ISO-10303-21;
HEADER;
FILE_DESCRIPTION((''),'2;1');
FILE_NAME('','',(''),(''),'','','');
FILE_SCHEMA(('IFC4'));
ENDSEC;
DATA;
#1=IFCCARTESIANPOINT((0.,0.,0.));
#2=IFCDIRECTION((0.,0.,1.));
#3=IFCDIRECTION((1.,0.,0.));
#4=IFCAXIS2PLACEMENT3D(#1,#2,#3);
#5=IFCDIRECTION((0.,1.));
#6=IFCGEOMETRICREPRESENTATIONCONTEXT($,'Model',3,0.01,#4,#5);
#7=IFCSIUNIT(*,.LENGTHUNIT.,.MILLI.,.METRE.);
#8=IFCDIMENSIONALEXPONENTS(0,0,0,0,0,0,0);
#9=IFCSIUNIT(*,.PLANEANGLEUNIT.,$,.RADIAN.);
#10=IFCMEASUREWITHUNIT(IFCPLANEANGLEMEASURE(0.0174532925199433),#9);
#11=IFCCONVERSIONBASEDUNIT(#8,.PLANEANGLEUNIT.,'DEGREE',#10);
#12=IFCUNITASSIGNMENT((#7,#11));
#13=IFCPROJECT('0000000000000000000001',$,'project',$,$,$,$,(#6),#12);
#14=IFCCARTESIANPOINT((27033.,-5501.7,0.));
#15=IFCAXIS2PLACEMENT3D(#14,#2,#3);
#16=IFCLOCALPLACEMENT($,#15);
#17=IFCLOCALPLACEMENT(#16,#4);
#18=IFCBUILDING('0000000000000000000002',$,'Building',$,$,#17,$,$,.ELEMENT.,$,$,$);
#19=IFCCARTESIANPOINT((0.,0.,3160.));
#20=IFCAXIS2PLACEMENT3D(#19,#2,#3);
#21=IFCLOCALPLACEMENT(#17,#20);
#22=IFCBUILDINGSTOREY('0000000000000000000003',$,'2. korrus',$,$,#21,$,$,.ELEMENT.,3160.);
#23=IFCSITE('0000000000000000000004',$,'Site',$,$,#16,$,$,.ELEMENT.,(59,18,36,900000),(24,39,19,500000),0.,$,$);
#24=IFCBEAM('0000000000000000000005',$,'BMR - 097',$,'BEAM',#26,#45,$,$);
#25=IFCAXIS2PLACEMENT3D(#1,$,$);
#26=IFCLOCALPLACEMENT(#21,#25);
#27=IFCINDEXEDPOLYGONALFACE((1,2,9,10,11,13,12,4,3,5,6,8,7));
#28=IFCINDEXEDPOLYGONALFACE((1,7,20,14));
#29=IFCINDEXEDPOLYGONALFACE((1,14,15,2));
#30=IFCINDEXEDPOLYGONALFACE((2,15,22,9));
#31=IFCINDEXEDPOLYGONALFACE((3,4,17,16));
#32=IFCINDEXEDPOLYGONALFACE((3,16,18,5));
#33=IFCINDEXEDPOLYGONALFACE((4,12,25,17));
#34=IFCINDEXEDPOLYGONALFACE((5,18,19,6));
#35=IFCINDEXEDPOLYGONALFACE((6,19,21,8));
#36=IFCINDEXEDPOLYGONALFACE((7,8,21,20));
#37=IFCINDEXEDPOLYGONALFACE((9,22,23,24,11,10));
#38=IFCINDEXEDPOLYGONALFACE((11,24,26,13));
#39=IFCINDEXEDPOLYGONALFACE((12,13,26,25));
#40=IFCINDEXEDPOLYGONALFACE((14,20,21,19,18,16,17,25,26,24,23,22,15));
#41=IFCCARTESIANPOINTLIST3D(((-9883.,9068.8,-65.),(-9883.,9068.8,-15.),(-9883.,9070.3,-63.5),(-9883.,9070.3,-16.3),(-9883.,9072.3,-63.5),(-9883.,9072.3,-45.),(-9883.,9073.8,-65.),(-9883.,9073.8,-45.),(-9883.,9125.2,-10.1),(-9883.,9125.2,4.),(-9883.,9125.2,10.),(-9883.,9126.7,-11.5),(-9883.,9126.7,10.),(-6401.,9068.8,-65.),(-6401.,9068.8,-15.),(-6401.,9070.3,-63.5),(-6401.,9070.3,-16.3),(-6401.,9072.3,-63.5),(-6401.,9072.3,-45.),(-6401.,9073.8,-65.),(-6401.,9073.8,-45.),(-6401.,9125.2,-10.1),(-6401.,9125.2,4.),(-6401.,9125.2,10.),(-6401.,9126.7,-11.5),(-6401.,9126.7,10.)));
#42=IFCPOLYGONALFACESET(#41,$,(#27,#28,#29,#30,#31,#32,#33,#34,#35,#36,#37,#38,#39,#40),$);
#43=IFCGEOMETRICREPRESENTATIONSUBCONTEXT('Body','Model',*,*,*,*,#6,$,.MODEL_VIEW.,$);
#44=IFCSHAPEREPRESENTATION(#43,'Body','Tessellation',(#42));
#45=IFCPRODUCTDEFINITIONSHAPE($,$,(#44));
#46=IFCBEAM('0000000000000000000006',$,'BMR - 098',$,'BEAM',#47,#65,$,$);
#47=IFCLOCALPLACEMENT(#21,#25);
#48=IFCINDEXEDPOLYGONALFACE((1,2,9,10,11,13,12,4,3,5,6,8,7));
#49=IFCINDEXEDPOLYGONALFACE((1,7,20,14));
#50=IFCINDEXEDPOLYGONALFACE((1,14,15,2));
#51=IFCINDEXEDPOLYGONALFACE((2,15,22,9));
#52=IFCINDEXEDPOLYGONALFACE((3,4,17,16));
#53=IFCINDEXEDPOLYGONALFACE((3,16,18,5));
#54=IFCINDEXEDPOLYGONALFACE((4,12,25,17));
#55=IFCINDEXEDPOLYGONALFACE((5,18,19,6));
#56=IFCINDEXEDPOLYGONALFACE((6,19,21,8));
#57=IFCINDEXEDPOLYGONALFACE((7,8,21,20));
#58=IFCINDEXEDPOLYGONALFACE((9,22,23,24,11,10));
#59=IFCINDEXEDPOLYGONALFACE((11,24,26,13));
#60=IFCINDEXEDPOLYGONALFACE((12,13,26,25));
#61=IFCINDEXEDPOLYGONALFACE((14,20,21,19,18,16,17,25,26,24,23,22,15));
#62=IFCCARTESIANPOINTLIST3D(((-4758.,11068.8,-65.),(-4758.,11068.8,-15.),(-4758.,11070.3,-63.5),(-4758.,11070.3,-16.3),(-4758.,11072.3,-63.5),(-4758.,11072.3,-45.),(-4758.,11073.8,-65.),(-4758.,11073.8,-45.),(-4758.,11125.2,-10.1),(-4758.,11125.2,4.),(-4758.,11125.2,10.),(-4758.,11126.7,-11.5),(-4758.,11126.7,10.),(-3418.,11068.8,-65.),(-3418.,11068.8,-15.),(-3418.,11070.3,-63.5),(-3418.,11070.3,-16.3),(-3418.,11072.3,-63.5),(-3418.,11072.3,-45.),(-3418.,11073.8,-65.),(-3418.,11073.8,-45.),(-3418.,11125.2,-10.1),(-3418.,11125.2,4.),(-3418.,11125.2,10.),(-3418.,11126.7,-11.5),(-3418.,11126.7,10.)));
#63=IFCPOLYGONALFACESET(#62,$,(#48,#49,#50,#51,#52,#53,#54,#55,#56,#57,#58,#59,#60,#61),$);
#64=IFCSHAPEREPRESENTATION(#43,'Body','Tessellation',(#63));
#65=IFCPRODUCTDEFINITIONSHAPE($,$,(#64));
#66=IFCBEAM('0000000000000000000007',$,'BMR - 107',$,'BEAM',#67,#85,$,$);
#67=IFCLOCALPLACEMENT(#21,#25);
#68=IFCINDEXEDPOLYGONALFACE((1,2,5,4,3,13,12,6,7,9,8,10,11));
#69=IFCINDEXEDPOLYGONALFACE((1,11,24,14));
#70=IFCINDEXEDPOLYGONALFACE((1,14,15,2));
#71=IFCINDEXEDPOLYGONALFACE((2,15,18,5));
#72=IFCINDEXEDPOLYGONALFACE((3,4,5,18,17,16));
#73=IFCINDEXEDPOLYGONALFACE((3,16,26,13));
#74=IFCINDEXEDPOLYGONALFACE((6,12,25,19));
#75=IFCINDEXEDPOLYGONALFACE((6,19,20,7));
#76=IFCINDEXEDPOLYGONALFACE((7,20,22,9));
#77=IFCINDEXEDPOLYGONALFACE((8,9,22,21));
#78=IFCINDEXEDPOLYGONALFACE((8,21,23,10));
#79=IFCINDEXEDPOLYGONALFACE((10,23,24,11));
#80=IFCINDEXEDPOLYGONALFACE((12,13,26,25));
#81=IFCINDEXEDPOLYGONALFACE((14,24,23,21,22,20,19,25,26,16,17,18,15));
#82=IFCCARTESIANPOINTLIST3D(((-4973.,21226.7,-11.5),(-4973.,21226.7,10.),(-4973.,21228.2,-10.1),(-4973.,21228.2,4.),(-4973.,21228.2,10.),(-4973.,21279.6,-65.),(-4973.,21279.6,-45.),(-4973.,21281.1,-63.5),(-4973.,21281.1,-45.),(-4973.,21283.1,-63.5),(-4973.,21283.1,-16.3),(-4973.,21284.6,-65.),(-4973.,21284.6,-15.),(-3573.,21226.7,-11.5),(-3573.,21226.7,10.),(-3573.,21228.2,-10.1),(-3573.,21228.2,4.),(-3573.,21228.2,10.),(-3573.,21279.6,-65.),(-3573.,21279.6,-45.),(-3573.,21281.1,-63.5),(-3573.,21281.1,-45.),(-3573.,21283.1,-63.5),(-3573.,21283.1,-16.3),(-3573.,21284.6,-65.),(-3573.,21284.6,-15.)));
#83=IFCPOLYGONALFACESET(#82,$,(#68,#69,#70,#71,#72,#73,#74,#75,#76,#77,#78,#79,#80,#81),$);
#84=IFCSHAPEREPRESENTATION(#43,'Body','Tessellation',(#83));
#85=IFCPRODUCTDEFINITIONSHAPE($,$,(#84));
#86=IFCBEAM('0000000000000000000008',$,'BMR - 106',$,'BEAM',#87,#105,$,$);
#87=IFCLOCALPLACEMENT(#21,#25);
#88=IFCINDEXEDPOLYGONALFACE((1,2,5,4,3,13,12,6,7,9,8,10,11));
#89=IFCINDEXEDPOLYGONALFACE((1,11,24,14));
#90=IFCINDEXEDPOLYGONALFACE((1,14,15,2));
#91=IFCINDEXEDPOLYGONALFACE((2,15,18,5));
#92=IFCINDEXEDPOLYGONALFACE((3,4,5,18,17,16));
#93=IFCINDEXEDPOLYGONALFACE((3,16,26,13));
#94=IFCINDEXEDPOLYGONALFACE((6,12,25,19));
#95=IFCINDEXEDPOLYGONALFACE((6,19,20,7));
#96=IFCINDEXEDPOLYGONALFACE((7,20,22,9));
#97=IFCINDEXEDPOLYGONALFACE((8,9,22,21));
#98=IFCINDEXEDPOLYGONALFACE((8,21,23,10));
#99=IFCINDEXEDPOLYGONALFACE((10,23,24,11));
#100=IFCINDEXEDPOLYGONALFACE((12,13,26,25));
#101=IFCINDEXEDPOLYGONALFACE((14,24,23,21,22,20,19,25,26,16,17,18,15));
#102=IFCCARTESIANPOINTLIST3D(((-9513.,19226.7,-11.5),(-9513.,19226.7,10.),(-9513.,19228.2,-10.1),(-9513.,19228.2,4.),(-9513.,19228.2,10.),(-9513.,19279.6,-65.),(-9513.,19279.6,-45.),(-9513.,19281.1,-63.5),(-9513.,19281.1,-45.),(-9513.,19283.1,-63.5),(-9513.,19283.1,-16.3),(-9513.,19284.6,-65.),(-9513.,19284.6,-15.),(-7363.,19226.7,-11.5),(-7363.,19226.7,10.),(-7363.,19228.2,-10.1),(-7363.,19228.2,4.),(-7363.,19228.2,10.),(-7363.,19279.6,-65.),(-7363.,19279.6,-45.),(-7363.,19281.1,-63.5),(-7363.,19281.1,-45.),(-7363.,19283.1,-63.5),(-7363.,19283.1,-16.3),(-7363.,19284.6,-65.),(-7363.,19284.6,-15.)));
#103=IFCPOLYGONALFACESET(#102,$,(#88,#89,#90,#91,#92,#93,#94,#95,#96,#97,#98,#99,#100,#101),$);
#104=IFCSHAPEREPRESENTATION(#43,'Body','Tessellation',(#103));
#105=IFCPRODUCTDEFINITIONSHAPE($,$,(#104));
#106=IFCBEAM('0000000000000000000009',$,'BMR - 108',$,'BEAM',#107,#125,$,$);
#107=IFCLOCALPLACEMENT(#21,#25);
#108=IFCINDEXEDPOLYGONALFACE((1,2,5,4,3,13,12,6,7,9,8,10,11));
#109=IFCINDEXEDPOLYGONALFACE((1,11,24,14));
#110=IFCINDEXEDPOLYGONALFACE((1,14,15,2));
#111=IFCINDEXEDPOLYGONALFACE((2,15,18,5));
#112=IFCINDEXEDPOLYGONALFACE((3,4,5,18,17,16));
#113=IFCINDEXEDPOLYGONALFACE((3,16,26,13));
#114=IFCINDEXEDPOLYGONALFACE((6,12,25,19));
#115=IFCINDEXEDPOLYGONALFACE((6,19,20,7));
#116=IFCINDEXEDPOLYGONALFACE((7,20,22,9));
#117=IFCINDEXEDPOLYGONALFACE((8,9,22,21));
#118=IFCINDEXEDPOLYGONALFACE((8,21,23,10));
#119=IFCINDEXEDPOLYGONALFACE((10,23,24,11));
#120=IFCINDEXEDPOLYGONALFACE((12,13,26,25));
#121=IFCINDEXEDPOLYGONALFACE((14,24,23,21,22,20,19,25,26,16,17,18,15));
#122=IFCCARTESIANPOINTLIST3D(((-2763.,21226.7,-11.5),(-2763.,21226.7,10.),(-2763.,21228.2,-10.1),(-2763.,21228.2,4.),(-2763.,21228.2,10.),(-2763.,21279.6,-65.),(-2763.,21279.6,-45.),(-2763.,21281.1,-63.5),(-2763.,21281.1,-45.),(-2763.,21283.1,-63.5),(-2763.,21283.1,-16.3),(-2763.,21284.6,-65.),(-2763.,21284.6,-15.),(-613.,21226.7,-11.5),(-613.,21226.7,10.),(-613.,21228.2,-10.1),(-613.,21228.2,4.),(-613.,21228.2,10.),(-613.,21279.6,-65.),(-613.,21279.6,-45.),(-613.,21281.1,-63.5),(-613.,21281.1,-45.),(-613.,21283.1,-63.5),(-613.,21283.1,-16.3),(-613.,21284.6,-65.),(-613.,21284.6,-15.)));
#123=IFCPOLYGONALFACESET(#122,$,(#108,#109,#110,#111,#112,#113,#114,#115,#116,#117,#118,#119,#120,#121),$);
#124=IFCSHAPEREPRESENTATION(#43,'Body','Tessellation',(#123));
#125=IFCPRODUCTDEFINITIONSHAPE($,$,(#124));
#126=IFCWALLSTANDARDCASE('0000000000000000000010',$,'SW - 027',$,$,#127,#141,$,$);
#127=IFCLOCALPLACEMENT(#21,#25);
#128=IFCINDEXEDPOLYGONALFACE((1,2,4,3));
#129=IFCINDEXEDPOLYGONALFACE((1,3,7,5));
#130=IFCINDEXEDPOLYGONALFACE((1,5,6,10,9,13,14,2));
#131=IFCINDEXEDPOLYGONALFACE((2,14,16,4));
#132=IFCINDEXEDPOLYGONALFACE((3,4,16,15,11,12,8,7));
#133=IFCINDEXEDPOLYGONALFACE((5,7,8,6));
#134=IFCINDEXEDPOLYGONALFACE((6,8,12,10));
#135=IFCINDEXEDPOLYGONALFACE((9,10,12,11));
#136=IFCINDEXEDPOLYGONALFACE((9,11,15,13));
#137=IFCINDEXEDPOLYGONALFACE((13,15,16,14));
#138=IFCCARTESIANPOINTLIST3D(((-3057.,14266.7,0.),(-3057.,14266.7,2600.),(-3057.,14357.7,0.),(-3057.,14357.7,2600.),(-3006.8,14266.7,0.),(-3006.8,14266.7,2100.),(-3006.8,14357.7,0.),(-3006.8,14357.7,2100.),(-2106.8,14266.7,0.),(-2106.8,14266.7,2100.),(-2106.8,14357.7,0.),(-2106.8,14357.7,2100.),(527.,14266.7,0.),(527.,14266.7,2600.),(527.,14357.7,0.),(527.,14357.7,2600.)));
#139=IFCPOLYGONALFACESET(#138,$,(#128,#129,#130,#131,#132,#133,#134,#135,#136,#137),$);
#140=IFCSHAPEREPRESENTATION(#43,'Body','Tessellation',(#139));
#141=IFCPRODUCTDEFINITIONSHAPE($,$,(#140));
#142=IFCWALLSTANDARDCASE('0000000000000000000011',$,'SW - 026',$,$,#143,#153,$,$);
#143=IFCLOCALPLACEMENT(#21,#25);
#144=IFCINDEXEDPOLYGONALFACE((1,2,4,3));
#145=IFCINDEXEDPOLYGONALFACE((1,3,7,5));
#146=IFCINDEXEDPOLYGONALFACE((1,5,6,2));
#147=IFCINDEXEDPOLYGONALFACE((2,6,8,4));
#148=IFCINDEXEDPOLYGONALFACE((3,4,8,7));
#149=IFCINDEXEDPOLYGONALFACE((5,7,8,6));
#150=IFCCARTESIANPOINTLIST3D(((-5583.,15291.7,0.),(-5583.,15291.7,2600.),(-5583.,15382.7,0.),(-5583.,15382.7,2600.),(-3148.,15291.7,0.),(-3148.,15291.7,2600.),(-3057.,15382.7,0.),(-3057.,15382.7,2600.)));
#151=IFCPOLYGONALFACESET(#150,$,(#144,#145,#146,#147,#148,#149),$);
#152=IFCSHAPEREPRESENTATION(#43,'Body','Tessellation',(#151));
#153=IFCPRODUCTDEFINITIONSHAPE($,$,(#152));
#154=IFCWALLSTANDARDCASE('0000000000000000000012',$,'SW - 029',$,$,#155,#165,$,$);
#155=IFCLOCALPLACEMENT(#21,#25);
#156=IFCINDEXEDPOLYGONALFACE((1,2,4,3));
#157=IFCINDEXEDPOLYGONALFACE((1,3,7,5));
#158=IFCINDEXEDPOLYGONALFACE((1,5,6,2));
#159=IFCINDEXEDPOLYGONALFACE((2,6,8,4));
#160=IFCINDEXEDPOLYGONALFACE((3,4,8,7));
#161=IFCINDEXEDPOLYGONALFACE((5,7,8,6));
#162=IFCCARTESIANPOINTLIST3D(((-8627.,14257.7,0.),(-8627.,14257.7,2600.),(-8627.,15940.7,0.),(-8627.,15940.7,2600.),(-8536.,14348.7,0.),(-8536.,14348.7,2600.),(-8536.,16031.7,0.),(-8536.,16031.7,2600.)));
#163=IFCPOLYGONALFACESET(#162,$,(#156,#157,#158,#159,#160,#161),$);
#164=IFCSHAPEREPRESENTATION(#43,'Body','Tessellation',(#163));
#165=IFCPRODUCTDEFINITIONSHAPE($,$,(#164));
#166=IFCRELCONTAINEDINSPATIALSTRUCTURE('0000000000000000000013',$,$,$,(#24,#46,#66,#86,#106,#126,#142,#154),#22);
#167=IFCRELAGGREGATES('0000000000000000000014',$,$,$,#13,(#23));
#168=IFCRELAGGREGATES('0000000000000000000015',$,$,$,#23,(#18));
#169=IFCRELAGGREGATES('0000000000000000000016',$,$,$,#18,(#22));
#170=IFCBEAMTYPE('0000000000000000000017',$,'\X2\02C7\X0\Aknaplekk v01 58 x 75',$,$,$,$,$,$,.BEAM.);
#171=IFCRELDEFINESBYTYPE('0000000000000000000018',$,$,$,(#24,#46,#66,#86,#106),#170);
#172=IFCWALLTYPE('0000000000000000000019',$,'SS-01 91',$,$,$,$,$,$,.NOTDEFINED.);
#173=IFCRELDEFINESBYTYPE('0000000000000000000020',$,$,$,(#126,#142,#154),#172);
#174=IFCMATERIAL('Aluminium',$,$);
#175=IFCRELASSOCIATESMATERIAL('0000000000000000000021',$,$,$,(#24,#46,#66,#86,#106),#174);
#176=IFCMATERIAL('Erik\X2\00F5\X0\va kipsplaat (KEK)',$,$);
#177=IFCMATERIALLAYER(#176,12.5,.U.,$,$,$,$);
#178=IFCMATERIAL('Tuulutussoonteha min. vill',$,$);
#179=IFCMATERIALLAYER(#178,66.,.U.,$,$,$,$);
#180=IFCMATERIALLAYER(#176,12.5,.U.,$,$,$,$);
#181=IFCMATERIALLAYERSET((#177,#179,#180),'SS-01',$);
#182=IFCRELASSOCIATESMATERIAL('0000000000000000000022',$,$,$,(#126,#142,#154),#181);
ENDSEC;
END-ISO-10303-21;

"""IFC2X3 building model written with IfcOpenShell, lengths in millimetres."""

from ifc_helpers import new_model, entity, si_unit, converted_unit, direction, frame, origin_with_axes, origin_2d_with_axis, place, context, subcontext, project, spatial, polyline, rectangle, outline, extrude, material, layer, layer_set, layer_usage, type_object, element, save


model = new_model("IFC2X3")

# Units and contexts
model_context = context("Model", 3, precision=0.01, world=origin_with_axes(), true_north=direction((0.0, 1.0)))
body_context = subcontext(model_context, "Body", "Model", "MODEL_VIEW")
ifc_project = project(units=[si_unit("LENGTHUNIT", "METRE", prefix="MILLI"), converted_unit("PLANEANGLEUNIT", "DEGREE", entity("IfcPlaneAngleMeasure", 0.0174532925199433), si_unit("PLANEANGLEUNIT", "RADIAN"), dimensions=[0, 0, 0, 0, 0, 0, 0])], contexts=[model_context])

# Site, building, storey
site_placement = place(None, frame((27033.0, -5501.7, 0.0), z_axis=(0.0, 0.0, 1.0), x_axis=(1.0, 0.0, 0.0)))
site = spatial("IfcSite", under=ifc_project, at=site_placement, Name="Site", CompositionType="ELEMENT", RefLatitude=(59, 18, 36, 900000), RefLongitude=(24, 39, 19, 500000), RefElevation=0.0)
building_placement = place(site_placement, origin_with_axes())
building = spatial("IfcBuilding", under=site, at=building_placement, Name="Building", CompositionType="ELEMENT")
storey_placement = place(building_placement, frame((0.0, 0.0, 3160.0), z_axis=(0.0, 0.0, 1.0), x_axis=(1.0, 0.0, 0.0)))
storey = spatial("IfcBuildingStorey", under=building, at=storey_placement, Name="2. korrus", CompositionType="ELEMENT", Elevation=3160.0)

# Beams
ifc_material_1 = material(Name="Aluminium")
beam_type = type_object("IfcBeamType", Name="ˇAknaplekk v01 58 x 75", PredefinedType="BEAM")
beam_1_placement = place(storey_placement, frame((-6401.0, 9126.7, 0.0), z_axis=(0.0, 0.0, 1.0), x_axis=(0.0, 1.0, 0.0)))
element("IfcBeam", 1, at=beam_1_placement, inside=storey, type_object=beam_type, material=ifc_material_1, Name="BMR - 097", ObjectType="BEAM", context=body_context, shape_type="SweptSolid", body=[
    extrude(outline(polyline([(-57.9, -15.0), (-57.9, -65.0), (-52.9, -65.0), (-52.9, -45.0), (-54.4, -45.0), (-54.4, -63.5), (-56.4, -63.5), (-56.4, -16.3), (0.0, -11.5), (0.0, 10.0), (-1.5, 10.0), (-1.5, 4.0), (-1.5, -10.1), (-57.9, -15.0)])), frame((0.0, 3482.0, 0.0), z_axis=(0.0, -1.0, 0.0), x_axis=(1.0, 0.0, 0.0)), (0.0, 0.0, 1.0), 3482.0),
])
beam_2_placement = place(storey_placement, frame((-3418.0, 11126.7, 0.0), z_axis=(0.0, 0.0, 1.0), x_axis=(0.0, 1.0, 0.0)))
element("IfcBeam", 2, at=beam_2_placement, inside=storey, type_object=beam_type, material=ifc_material_1, Name="BMR - 098", ObjectType="BEAM", context=body_context, shape_type="SweptSolid", body=[
    extrude(outline(polyline([(-57.9, -15.0), (-57.9, -65.0), (-52.9, -65.0), (-52.9, -45.0), (-54.4, -45.0), (-54.4, -63.5), (-56.4, -63.5), (-56.4, -16.3), (0.0, -11.5), (0.0, 10.0), (-1.5, 10.0), (-1.5, 4.0), (-1.5, -10.1), (-57.9, -15.0)])), frame((0.0, 1340.0, 0.0), z_axis=(0.0, -1.0, 0.0), x_axis=(1.0, 0.0, 0.0)), (0.0, 0.0, 1.0), 1340.0),
])
beam_3_placement = place(storey_placement, frame((-4973.0, 21226.7, 0.0), z_axis=(0.0, 0.0, 1.0), x_axis=(0.0, -1.0, 0.0)))
element("IfcBeam", 3, at=beam_3_placement, inside=storey, type_object=beam_type, material=ifc_material_1, Name="BMR - 107", ObjectType="BEAM", context=body_context, shape_type="SweptSolid", body=[
    extrude(outline(polyline([(-57.9, -15.0), (-57.9, -65.0), (-52.9, -65.0), (-52.9, -45.0), (-54.4, -45.0), (-54.4, -63.5), (-56.4, -63.5), (-56.4, -16.3), (0.0, -11.5), (0.0, 10.0), (-1.5, 10.0), (-1.5, 4.0), (-1.5, -10.1), (-57.9, -15.0)])), frame((0.0, 1400.0, 0.0), z_axis=(0.0, -1.0, 0.0), x_axis=(1.0, 0.0, 0.0)), (0.0, 0.0, 1.0), 1400.0),
])
beam_4_placement = place(storey_placement, frame((-9513.0, 19226.7, 0.0), z_axis=(0.0, 0.0, 1.0), x_axis=(0.0, -1.0, 0.0)))
element("IfcBeam", 4, at=beam_4_placement, inside=storey, type_object=beam_type, material=ifc_material_1, Name="BMR - 106", ObjectType="BEAM", context=body_context, shape_type="SweptSolid", body=[
    extrude(outline(polyline([(-57.9, -15.0), (-57.9, -65.0), (-52.9, -65.0), (-52.9, -45.0), (-54.4, -45.0), (-54.4, -63.5), (-56.4, -63.5), (-56.4, -16.3), (0.0, -11.5), (0.0, 10.0), (-1.5, 10.0), (-1.5, 4.0), (-1.5, -10.1), (-57.9, -15.0)])), frame((0.0, 2150.0, 0.0), z_axis=(0.0, -1.0, 0.0), x_axis=(1.0, 0.0, 0.0)), (0.0, 0.0, 1.0), 2150.0),
])
beam_5_placement = place(storey_placement, frame((-2763.0, 21226.7, 0.0), z_axis=(0.0, 0.0, 1.0), x_axis=(0.0, -1.0, 0.0)))
element("IfcBeam", 5, at=beam_5_placement, inside=storey, type_object=beam_type, material=ifc_material_1, Name="BMR - 108", ObjectType="BEAM", context=body_context, shape_type="SweptSolid", body=[
    extrude(outline(polyline([(-57.9, -15.0), (-57.9, -65.0), (-52.9, -65.0), (-52.9, -45.0), (-54.4, -45.0), (-54.4, -63.5), (-56.4, -63.5), (-56.4, -16.3), (0.0, -11.5), (0.0, 10.0), (-1.5, 10.0), (-1.5, 4.0), (-1.5, -10.1), (-57.9, -15.0)])), frame((0.0, 2150.0, 0.0), z_axis=(0.0, -1.0, 0.0), x_axis=(1.0, 0.0, 0.0)), (0.0, 0.0, 1.0), 2150.0),
])

# Wall, opening
ifc_material_2 = material(Name="Erikõva kipsplaat (KEK)")
ifc_layer_1 = layer(ifc_material_2, 12.5, ventilated="UNKNOWN")
ifc_material_3 = material(Name="Tuulutussoonteha min. vill")
ifc_layer_2 = layer(ifc_material_3, 66.0, ventilated="UNKNOWN")
ifc_layer_3 = layer(ifc_material_2, 12.5, ventilated="UNKNOWN")
ifc_layer_set_1 = layer_set([ifc_layer_1, ifc_layer_2, ifc_layer_3], Name="SS-01")
ifc_layer_usage_1 = layer_usage(ifc_layer_set_1, "AXIS2", "POSITIVE", -91.0)
wall_type_1 = type_object("IfcWallType", Name="SS-01 91", PredefinedType="NOTDEFINED")
wall_1_placement = place(storey_placement, frame((-3057.0, 14357.7, 0.0), z_axis=(0.0, 0.0, 1.0), x_axis=(1.0, 0.0, 0.0)))
wall_1 = element("IfcWallStandardCase", 6, at=wall_1_placement, inside=storey, type_object=wall_type_1, material=ifc_layer_usage_1, Name="SW - 027", context=body_context, shape_type="SweptSolid", body=[
    extrude(outline(polyline([(0.0, -91.0), (3584.0, -91.0), (3584.0, 0.0), (0.0, 0.0), (0.0, -91.0)])), origin_with_axes(), (0.0, 0.0, 1.0), 2600.0),
])
opening_1_placement = place(wall_1_placement, frame((500.2, 0.0, 0.0), z_axis=(0.0, 0.0, 1.0), x_axis=(1.0, 0.0, 0.0)))
element("IfcOpeningElement", 7, at=opening_1_placement, cuts=wall_1, context=body_context, shape_type="SweptSolid", body=[
    extrude(rectangle(XDim=900.0, YDim=2100.0, at=origin_2d_with_axis()), frame((0.0, -91.0, 1050.0), z_axis=(0.0, 1.0, 0.0), x_axis=(-1.0, 0.0, 0.0)), (0.0, 0.0, 1.0), 273.0),
    extrude(rectangle(XDim=974.0, YDim=2137.0, at=origin_2d_with_axis()), frame((0.0, 0.0, 1068.5), z_axis=(0.0, -1.0, 0.0), x_axis=(-1.0, 0.0, 0.0)), (0.0, 0.0, -1.0), 91.0),
])

# Wall
ifc_layer_usage_2 = layer_usage(ifc_layer_set_1, "AXIS2", "NEGATIVE", 91.0)
wall_2_placement = place(storey_placement, frame((-5583.0, 15291.7, 0.0), z_axis=(0.0, 0.0, 1.0), x_axis=(1.0, 0.0, 0.0)))
element("IfcWallStandardCase", 8, at=wall_2_placement, inside=storey, type_object=wall_type_1, material=ifc_layer_usage_2, Name="SW - 026", context=body_context, shape_type="SweptSolid", body=[
    extrude(outline(polyline([(0.0, 0.0), (2435.0, 0.0), (2526.0, 91.0), (0.0, 91.0), (0.0, 0.0)])), origin_with_axes(), (0.0, 0.0, 1.0), 2600.0),
])

# Wall
ifc_layer_usage_3 = layer_usage(ifc_layer_set_1, "AXIS2", "POSITIVE", -91.0)
wall_3_placement = place(storey_placement, frame((-8627.0, 14257.7, 0.0), z_axis=(0.0, 0.0, 1.0), x_axis=(0.0, 1.0, 0.0)))
element("IfcWallStandardCase", 9, at=wall_3_placement, inside=storey, type_object=wall_type_1, material=ifc_layer_usage_3, Name="SW - 029", context=body_context, shape_type="SweptSolid", body=[
    extrude(outline(polyline([(91.0, -91.0), (1774.0, -91.0), (1683.0, 0.0), (0.0, 0.0), (91.0, -91.0)])), origin_with_axes(), (0.0, 0.0, 1.0), 2600.0),
])

save(model, "model.ifc")
